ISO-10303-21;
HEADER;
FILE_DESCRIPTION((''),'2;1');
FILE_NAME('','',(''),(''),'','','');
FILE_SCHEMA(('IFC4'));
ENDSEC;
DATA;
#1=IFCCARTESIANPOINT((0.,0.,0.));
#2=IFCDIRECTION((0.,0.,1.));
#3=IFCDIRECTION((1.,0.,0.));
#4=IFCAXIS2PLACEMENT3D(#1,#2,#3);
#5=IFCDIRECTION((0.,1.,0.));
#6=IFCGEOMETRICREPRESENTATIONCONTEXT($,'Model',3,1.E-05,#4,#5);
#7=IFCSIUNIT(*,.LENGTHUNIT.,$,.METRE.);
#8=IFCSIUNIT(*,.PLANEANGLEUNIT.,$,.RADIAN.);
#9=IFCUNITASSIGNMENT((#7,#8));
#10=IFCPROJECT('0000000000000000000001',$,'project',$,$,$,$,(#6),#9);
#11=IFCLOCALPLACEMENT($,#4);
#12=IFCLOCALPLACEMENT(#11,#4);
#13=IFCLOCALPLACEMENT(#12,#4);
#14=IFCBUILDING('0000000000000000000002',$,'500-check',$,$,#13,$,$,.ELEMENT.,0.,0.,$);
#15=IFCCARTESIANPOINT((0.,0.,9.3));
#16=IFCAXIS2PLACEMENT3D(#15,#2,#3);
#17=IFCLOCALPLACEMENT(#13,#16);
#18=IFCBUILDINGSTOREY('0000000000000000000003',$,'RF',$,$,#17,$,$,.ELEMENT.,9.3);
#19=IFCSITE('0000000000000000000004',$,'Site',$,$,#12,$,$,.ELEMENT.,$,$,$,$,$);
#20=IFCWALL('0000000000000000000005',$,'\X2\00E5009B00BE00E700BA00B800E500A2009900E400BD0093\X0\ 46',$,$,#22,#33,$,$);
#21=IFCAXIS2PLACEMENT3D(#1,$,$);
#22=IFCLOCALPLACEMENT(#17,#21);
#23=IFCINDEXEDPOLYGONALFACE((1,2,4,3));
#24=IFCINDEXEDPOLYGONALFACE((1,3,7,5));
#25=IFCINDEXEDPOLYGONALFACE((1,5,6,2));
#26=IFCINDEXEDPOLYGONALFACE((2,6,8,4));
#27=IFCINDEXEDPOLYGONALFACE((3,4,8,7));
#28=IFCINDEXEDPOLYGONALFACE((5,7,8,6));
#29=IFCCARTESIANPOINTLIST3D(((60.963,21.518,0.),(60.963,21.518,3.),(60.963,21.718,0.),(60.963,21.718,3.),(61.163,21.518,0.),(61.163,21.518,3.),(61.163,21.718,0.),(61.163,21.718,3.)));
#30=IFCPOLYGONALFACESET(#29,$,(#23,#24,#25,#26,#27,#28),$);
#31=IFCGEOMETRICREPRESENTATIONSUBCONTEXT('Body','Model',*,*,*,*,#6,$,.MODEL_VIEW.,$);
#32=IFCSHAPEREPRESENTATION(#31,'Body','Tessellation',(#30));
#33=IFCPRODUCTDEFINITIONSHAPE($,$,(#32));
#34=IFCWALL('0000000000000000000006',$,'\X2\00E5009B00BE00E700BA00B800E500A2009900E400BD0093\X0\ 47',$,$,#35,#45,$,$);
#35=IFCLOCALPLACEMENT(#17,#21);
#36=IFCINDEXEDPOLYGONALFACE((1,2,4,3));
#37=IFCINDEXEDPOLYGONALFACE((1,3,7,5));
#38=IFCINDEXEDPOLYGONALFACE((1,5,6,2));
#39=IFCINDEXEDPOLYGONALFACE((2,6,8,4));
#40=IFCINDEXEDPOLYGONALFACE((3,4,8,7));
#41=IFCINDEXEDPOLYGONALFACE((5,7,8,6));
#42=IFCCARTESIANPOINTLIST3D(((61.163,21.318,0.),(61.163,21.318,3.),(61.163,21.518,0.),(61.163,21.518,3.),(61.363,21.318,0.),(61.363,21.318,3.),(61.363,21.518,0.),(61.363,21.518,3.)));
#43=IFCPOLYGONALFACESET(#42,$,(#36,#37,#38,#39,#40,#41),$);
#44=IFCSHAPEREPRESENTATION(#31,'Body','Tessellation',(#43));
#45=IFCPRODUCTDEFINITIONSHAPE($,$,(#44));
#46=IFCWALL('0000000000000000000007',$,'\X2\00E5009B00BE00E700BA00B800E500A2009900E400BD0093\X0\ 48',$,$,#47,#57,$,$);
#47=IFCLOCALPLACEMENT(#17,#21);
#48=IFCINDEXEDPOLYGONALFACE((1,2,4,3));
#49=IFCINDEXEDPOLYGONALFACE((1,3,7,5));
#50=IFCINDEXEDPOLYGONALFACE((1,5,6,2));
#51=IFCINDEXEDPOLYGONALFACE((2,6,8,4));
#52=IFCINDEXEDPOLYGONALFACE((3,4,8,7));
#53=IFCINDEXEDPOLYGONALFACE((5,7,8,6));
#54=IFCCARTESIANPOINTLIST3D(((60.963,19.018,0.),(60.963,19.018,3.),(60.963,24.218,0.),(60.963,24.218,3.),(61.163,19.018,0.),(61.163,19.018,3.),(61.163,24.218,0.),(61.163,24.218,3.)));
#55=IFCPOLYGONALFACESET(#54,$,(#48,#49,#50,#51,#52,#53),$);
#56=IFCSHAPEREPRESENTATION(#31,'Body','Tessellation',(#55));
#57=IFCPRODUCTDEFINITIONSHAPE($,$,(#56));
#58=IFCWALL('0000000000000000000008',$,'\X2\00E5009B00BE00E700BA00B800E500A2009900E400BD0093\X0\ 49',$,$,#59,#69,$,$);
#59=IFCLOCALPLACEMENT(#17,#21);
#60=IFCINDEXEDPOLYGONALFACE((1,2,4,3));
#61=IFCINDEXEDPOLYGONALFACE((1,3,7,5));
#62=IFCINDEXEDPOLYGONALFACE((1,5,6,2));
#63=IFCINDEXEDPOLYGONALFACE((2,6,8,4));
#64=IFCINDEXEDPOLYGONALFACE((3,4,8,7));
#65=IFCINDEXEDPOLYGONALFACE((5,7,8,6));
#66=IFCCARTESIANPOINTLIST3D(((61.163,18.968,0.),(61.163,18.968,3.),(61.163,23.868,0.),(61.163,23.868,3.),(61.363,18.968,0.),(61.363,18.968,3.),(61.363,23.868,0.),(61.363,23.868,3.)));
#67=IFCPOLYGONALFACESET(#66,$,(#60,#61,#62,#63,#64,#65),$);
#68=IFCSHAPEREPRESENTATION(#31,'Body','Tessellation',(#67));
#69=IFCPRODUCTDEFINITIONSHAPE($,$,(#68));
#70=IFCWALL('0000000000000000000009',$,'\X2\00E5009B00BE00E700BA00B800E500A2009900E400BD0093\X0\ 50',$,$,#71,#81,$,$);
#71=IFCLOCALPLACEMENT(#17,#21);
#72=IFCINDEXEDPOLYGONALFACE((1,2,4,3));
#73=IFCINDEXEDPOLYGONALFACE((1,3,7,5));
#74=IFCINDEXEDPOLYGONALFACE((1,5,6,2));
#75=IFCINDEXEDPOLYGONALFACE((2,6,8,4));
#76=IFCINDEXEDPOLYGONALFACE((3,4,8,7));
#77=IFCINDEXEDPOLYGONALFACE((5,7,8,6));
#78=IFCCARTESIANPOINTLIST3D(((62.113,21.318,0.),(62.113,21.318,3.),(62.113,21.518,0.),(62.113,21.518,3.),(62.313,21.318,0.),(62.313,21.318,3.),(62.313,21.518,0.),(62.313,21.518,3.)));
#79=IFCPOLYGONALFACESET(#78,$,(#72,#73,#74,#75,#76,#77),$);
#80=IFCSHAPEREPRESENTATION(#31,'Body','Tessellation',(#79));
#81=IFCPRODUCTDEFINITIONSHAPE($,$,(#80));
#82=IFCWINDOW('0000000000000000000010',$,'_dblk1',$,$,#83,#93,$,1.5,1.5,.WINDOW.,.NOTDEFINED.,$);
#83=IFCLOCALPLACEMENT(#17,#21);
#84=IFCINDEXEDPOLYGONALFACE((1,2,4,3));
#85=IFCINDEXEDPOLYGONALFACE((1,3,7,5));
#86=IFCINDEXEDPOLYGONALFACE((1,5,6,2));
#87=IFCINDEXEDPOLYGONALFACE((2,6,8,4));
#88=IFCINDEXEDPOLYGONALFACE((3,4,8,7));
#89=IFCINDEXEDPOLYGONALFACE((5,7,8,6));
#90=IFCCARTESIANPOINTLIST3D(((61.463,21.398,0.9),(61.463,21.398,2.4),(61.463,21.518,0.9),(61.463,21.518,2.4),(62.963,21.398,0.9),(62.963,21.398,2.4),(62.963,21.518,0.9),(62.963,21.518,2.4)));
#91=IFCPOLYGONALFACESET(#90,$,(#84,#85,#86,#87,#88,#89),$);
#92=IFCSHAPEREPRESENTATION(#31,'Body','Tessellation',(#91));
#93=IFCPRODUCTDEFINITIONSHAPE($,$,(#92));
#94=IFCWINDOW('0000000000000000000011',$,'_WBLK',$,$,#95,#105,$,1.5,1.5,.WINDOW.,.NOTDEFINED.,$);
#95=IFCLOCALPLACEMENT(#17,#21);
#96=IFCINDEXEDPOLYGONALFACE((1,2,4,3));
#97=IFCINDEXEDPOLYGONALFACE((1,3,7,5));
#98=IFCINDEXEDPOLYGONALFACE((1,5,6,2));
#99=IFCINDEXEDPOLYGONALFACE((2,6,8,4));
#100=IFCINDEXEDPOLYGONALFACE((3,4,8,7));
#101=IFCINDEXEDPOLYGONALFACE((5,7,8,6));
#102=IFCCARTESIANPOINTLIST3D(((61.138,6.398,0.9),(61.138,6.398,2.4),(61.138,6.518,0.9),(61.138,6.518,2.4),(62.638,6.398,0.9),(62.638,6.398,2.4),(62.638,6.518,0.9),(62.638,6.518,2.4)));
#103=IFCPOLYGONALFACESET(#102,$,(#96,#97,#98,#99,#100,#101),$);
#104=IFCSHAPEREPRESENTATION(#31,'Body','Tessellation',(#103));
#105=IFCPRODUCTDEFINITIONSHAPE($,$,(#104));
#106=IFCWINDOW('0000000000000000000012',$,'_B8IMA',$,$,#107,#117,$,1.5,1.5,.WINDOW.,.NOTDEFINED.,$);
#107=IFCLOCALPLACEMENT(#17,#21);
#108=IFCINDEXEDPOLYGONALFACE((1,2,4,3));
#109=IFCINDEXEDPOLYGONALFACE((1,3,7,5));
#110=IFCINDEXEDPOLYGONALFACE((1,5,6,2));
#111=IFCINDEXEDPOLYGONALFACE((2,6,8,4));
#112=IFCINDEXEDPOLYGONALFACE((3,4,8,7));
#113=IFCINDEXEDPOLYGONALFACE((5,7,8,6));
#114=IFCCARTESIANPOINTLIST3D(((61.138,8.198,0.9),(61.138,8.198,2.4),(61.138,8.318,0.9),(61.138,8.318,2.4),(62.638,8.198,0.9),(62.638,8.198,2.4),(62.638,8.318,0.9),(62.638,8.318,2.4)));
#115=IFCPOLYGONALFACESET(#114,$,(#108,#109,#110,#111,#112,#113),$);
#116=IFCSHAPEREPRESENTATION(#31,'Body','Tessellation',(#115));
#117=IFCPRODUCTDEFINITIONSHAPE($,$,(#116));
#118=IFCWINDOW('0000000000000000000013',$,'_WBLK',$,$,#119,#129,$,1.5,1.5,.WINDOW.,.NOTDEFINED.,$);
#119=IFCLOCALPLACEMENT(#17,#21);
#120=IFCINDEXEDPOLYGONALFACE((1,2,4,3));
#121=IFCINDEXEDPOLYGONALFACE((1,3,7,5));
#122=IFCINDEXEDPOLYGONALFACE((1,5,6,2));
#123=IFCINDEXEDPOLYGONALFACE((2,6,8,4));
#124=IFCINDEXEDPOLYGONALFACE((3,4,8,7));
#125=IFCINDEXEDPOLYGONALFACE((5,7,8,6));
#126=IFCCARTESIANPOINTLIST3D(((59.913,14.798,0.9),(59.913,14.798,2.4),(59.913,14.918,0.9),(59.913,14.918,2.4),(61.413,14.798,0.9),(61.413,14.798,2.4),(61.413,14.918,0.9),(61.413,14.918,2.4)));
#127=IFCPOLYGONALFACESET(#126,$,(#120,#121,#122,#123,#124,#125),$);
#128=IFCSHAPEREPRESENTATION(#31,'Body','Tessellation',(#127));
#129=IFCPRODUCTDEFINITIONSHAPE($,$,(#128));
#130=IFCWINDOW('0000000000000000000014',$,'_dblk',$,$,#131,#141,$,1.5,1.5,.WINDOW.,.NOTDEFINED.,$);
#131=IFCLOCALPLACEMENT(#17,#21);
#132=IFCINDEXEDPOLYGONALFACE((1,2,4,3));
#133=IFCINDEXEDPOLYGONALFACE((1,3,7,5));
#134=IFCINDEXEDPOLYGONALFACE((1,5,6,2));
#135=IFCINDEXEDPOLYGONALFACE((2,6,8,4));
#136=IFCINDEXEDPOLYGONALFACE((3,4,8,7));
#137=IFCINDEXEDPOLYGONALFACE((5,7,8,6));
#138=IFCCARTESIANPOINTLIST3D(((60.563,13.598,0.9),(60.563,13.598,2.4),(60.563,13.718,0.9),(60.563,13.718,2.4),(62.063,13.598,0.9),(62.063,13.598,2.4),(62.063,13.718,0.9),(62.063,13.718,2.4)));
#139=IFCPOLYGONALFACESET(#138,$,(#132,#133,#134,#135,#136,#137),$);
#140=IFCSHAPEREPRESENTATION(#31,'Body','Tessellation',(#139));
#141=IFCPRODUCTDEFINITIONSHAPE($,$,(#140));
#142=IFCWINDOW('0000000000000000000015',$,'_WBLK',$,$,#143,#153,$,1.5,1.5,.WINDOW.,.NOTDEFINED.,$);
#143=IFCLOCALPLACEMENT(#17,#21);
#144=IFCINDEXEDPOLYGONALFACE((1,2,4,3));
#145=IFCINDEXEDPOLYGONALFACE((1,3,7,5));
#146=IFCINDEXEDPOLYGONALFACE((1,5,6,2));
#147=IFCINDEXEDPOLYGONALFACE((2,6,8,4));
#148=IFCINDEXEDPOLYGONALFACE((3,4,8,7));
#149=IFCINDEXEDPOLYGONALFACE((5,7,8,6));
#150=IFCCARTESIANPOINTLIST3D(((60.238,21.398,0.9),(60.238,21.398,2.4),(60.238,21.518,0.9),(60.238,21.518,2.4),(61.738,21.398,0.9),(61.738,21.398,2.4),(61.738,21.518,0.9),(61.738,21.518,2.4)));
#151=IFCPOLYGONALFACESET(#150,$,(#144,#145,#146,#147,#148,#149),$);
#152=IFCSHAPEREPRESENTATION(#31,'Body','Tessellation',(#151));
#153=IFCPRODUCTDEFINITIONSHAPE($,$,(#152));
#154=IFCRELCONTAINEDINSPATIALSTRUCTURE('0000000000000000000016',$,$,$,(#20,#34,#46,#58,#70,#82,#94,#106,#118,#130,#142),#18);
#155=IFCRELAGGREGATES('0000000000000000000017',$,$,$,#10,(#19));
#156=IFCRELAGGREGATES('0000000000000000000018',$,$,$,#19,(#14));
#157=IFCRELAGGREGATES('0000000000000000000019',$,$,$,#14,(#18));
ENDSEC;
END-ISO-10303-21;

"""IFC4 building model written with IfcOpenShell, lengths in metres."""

from ifc_helpers import new_model, si_unit, direction, frame, frame_2d, origin_with_axes, place, context, subcontext, project, spatial, rectangle, extrude, element, save


model = new_model("IFC4")

# Units and contexts
model_context = context("Model", 3, precision=1e-05, world=origin_with_axes(), true_north=direction((0.0, 1.0, 0.0)))
body_context = subcontext(model_context, "Body", "Model", "MODEL_VIEW")
ifc_project = project(units=[si_unit("LENGTHUNIT", "METRE"), si_unit("PLANEANGLEUNIT", "RADIAN")], contexts=[model_context])

# Site, building, storey
placement = place(None, origin_with_axes())
site_placement = place(placement, origin_with_axes())
site = spatial("IfcSite", under=ifc_project, at=site_placement, Name="Site", CompositionType="ELEMENT")
building_placement = place(site_placement, origin_with_axes())
building = spatial("IfcBuilding", under=site, at=building_placement, Name="500-check", CompositionType="ELEMENT", ElevationOfRefHeight=0.0, ElevationOfTerrain=0.0)
storey_placement = place(building_placement, frame((0.0, 0.0, 9.3), z_axis=(0.0, 0.0, 1.0), x_axis=(1.0, 0.0, 0.0)))
storey = spatial("IfcBuildingStorey", under=building, at=storey_placement, Name="RF", CompositionType="ELEMENT", Elevation=9.3)

# Walls
for number, where, z_axis, x_axis, name in (
    (1, (61.063, 21.618, 0.0), (0.0, 0.0, 1.0), (1.0, 0.0, 0.0), "å\u009b¾çº¸å¢\u0099ä½\u0093 46"),
    (2, (61.263, 21.418, 0.0), (0.0, 0.0, 1.0), (0.0, 1.0, 0.0), "å\u009b¾çº¸å¢\u0099ä½\u0093 47"),
):
    element("IfcWall", number, at=place(storey_placement, frame(where, z_axis=z_axis, x_axis=x_axis)), inside=storey, Name=name, context=body_context, shape_type="SweptSolid", body=[
        extrude(rectangle(XDim=0.2, YDim=0.2, at=frame_2d((0.0, 0.0), x_axis=(1.0, 0.0, 0.0))), frame((0.0, 0.0, 0.0), z_axis=(0.0, 0.0, 1.0)), (0.0, 0.0, 1.0), 3.0),
    ])
wall_1_placement = place(storey_placement, frame((61.063, 21.618, 0.0), z_axis=(0.0, 0.0, 1.0), x_axis=(0.0, -1.0, 0.0)))
element("IfcWall", 3, at=wall_1_placement, inside=storey, Name="å\u009b¾çº¸å¢\u0099ä½\u0093 48", context=body_context, shape_type="SweptSolid", body=[
    extrude(rectangle(XDim=5.2, YDim=0.2, at=frame_2d((0.0, 0.0), x_axis=(1.0, 0.0, 0.0))), frame((0.0, 0.0, 0.0), z_axis=(0.0, 0.0, 1.0)), (0.0, 0.0, 1.0), 3.0),
])
wall_2_placement = place(storey_placement, frame((61.263, 21.418, 0.0), z_axis=(0.0, 0.0, 1.0), x_axis=(0.0, -1.0, 0.0)))
element("IfcWall", 4, at=wall_2_placement, inside=storey, Name="å\u009b¾çº¸å¢\u0099ä½\u0093 49", context=body_context, shape_type="SweptSolid", body=[
    extrude(rectangle(XDim=4.9, YDim=0.2, at=frame_2d((0.0, 0.0), x_axis=(1.0, 0.0, 0.0))), frame((0.0, 0.0, 0.0), z_axis=(0.0, 0.0, 1.0)), (0.0, 0.0, 1.0), 3.0),
])
for number, where, z_axis, x_axis, name in (
    (5, (62.213, 21.418, 0.0), (0.0, 0.0, 1.0), (0.0, 1.0, 0.0), "å\u009b¾çº¸å¢\u0099ä½\u0093 50"),
):
    element("IfcWall", number, at=place(storey_placement, frame(where, z_axis=z_axis, x_axis=x_axis)), inside=storey, Name=name, context=body_context, shape_type="SweptSolid", body=[
        extrude(rectangle(XDim=0.2, YDim=0.2, at=frame_2d((0.0, 0.0), x_axis=(1.0, 0.0, 0.0))), frame((0.0, 0.0, 0.0), z_axis=(0.0, 0.0, 1.0)), (0.0, 0.0, 1.0), 3.0),
    ])

# Windows
for number, where, z_axis, x_axis, name in (
    (6, (62.213, 21.458, 0.9), (0.0, 0.0, 1.0), (1.0, 0.0, 0.0), "_dblk1"),
    (7, (61.888, 6.458, 0.9), (0.0, 0.0, 1.0), (1.0, 0.0, 0.0), "_WBLK"),
    (8, (61.888, 8.258, 0.9), (0.0, 0.0, 1.0), (1.0, 0.0, 0.0), "_B8IMA"),
    (9, (60.663, 14.858, 0.9), (0.0, 0.0, 1.0), (1.0, 0.0, 0.0), "_WBLK"),
    (10, (61.313, 13.658, 0.9), (0.0, 0.0, 1.0), (1.0, 0.0, 0.0), "_dblk"),
    (11, (60.988, 21.458, 0.9), (0.0, 0.0, 1.0), (1.0, 0.0, 0.0), "_WBLK"),
):
    element("IfcWindow", number, at=place(storey_placement, frame(where, z_axis=z_axis, x_axis=x_axis)), inside=storey, Name=name, OverallHeight=1.5, OverallWidth=1.5, PartitioningType="NOTDEFINED", PredefinedType="WINDOW", context=body_context, shape_type="SweptSolid", body=[
        extrude(rectangle(XDim=1.5, YDim=0.12, at=frame_2d((0.0, 0.0), x_axis=(1.0, 0.0, 0.0))), frame((0.0, 0.0, 0.0), z_axis=(0.0, 0.0, 1.0)), (0.0, 0.0, 1.0), 1.5),
    ])

save(model, "model.ifc")
